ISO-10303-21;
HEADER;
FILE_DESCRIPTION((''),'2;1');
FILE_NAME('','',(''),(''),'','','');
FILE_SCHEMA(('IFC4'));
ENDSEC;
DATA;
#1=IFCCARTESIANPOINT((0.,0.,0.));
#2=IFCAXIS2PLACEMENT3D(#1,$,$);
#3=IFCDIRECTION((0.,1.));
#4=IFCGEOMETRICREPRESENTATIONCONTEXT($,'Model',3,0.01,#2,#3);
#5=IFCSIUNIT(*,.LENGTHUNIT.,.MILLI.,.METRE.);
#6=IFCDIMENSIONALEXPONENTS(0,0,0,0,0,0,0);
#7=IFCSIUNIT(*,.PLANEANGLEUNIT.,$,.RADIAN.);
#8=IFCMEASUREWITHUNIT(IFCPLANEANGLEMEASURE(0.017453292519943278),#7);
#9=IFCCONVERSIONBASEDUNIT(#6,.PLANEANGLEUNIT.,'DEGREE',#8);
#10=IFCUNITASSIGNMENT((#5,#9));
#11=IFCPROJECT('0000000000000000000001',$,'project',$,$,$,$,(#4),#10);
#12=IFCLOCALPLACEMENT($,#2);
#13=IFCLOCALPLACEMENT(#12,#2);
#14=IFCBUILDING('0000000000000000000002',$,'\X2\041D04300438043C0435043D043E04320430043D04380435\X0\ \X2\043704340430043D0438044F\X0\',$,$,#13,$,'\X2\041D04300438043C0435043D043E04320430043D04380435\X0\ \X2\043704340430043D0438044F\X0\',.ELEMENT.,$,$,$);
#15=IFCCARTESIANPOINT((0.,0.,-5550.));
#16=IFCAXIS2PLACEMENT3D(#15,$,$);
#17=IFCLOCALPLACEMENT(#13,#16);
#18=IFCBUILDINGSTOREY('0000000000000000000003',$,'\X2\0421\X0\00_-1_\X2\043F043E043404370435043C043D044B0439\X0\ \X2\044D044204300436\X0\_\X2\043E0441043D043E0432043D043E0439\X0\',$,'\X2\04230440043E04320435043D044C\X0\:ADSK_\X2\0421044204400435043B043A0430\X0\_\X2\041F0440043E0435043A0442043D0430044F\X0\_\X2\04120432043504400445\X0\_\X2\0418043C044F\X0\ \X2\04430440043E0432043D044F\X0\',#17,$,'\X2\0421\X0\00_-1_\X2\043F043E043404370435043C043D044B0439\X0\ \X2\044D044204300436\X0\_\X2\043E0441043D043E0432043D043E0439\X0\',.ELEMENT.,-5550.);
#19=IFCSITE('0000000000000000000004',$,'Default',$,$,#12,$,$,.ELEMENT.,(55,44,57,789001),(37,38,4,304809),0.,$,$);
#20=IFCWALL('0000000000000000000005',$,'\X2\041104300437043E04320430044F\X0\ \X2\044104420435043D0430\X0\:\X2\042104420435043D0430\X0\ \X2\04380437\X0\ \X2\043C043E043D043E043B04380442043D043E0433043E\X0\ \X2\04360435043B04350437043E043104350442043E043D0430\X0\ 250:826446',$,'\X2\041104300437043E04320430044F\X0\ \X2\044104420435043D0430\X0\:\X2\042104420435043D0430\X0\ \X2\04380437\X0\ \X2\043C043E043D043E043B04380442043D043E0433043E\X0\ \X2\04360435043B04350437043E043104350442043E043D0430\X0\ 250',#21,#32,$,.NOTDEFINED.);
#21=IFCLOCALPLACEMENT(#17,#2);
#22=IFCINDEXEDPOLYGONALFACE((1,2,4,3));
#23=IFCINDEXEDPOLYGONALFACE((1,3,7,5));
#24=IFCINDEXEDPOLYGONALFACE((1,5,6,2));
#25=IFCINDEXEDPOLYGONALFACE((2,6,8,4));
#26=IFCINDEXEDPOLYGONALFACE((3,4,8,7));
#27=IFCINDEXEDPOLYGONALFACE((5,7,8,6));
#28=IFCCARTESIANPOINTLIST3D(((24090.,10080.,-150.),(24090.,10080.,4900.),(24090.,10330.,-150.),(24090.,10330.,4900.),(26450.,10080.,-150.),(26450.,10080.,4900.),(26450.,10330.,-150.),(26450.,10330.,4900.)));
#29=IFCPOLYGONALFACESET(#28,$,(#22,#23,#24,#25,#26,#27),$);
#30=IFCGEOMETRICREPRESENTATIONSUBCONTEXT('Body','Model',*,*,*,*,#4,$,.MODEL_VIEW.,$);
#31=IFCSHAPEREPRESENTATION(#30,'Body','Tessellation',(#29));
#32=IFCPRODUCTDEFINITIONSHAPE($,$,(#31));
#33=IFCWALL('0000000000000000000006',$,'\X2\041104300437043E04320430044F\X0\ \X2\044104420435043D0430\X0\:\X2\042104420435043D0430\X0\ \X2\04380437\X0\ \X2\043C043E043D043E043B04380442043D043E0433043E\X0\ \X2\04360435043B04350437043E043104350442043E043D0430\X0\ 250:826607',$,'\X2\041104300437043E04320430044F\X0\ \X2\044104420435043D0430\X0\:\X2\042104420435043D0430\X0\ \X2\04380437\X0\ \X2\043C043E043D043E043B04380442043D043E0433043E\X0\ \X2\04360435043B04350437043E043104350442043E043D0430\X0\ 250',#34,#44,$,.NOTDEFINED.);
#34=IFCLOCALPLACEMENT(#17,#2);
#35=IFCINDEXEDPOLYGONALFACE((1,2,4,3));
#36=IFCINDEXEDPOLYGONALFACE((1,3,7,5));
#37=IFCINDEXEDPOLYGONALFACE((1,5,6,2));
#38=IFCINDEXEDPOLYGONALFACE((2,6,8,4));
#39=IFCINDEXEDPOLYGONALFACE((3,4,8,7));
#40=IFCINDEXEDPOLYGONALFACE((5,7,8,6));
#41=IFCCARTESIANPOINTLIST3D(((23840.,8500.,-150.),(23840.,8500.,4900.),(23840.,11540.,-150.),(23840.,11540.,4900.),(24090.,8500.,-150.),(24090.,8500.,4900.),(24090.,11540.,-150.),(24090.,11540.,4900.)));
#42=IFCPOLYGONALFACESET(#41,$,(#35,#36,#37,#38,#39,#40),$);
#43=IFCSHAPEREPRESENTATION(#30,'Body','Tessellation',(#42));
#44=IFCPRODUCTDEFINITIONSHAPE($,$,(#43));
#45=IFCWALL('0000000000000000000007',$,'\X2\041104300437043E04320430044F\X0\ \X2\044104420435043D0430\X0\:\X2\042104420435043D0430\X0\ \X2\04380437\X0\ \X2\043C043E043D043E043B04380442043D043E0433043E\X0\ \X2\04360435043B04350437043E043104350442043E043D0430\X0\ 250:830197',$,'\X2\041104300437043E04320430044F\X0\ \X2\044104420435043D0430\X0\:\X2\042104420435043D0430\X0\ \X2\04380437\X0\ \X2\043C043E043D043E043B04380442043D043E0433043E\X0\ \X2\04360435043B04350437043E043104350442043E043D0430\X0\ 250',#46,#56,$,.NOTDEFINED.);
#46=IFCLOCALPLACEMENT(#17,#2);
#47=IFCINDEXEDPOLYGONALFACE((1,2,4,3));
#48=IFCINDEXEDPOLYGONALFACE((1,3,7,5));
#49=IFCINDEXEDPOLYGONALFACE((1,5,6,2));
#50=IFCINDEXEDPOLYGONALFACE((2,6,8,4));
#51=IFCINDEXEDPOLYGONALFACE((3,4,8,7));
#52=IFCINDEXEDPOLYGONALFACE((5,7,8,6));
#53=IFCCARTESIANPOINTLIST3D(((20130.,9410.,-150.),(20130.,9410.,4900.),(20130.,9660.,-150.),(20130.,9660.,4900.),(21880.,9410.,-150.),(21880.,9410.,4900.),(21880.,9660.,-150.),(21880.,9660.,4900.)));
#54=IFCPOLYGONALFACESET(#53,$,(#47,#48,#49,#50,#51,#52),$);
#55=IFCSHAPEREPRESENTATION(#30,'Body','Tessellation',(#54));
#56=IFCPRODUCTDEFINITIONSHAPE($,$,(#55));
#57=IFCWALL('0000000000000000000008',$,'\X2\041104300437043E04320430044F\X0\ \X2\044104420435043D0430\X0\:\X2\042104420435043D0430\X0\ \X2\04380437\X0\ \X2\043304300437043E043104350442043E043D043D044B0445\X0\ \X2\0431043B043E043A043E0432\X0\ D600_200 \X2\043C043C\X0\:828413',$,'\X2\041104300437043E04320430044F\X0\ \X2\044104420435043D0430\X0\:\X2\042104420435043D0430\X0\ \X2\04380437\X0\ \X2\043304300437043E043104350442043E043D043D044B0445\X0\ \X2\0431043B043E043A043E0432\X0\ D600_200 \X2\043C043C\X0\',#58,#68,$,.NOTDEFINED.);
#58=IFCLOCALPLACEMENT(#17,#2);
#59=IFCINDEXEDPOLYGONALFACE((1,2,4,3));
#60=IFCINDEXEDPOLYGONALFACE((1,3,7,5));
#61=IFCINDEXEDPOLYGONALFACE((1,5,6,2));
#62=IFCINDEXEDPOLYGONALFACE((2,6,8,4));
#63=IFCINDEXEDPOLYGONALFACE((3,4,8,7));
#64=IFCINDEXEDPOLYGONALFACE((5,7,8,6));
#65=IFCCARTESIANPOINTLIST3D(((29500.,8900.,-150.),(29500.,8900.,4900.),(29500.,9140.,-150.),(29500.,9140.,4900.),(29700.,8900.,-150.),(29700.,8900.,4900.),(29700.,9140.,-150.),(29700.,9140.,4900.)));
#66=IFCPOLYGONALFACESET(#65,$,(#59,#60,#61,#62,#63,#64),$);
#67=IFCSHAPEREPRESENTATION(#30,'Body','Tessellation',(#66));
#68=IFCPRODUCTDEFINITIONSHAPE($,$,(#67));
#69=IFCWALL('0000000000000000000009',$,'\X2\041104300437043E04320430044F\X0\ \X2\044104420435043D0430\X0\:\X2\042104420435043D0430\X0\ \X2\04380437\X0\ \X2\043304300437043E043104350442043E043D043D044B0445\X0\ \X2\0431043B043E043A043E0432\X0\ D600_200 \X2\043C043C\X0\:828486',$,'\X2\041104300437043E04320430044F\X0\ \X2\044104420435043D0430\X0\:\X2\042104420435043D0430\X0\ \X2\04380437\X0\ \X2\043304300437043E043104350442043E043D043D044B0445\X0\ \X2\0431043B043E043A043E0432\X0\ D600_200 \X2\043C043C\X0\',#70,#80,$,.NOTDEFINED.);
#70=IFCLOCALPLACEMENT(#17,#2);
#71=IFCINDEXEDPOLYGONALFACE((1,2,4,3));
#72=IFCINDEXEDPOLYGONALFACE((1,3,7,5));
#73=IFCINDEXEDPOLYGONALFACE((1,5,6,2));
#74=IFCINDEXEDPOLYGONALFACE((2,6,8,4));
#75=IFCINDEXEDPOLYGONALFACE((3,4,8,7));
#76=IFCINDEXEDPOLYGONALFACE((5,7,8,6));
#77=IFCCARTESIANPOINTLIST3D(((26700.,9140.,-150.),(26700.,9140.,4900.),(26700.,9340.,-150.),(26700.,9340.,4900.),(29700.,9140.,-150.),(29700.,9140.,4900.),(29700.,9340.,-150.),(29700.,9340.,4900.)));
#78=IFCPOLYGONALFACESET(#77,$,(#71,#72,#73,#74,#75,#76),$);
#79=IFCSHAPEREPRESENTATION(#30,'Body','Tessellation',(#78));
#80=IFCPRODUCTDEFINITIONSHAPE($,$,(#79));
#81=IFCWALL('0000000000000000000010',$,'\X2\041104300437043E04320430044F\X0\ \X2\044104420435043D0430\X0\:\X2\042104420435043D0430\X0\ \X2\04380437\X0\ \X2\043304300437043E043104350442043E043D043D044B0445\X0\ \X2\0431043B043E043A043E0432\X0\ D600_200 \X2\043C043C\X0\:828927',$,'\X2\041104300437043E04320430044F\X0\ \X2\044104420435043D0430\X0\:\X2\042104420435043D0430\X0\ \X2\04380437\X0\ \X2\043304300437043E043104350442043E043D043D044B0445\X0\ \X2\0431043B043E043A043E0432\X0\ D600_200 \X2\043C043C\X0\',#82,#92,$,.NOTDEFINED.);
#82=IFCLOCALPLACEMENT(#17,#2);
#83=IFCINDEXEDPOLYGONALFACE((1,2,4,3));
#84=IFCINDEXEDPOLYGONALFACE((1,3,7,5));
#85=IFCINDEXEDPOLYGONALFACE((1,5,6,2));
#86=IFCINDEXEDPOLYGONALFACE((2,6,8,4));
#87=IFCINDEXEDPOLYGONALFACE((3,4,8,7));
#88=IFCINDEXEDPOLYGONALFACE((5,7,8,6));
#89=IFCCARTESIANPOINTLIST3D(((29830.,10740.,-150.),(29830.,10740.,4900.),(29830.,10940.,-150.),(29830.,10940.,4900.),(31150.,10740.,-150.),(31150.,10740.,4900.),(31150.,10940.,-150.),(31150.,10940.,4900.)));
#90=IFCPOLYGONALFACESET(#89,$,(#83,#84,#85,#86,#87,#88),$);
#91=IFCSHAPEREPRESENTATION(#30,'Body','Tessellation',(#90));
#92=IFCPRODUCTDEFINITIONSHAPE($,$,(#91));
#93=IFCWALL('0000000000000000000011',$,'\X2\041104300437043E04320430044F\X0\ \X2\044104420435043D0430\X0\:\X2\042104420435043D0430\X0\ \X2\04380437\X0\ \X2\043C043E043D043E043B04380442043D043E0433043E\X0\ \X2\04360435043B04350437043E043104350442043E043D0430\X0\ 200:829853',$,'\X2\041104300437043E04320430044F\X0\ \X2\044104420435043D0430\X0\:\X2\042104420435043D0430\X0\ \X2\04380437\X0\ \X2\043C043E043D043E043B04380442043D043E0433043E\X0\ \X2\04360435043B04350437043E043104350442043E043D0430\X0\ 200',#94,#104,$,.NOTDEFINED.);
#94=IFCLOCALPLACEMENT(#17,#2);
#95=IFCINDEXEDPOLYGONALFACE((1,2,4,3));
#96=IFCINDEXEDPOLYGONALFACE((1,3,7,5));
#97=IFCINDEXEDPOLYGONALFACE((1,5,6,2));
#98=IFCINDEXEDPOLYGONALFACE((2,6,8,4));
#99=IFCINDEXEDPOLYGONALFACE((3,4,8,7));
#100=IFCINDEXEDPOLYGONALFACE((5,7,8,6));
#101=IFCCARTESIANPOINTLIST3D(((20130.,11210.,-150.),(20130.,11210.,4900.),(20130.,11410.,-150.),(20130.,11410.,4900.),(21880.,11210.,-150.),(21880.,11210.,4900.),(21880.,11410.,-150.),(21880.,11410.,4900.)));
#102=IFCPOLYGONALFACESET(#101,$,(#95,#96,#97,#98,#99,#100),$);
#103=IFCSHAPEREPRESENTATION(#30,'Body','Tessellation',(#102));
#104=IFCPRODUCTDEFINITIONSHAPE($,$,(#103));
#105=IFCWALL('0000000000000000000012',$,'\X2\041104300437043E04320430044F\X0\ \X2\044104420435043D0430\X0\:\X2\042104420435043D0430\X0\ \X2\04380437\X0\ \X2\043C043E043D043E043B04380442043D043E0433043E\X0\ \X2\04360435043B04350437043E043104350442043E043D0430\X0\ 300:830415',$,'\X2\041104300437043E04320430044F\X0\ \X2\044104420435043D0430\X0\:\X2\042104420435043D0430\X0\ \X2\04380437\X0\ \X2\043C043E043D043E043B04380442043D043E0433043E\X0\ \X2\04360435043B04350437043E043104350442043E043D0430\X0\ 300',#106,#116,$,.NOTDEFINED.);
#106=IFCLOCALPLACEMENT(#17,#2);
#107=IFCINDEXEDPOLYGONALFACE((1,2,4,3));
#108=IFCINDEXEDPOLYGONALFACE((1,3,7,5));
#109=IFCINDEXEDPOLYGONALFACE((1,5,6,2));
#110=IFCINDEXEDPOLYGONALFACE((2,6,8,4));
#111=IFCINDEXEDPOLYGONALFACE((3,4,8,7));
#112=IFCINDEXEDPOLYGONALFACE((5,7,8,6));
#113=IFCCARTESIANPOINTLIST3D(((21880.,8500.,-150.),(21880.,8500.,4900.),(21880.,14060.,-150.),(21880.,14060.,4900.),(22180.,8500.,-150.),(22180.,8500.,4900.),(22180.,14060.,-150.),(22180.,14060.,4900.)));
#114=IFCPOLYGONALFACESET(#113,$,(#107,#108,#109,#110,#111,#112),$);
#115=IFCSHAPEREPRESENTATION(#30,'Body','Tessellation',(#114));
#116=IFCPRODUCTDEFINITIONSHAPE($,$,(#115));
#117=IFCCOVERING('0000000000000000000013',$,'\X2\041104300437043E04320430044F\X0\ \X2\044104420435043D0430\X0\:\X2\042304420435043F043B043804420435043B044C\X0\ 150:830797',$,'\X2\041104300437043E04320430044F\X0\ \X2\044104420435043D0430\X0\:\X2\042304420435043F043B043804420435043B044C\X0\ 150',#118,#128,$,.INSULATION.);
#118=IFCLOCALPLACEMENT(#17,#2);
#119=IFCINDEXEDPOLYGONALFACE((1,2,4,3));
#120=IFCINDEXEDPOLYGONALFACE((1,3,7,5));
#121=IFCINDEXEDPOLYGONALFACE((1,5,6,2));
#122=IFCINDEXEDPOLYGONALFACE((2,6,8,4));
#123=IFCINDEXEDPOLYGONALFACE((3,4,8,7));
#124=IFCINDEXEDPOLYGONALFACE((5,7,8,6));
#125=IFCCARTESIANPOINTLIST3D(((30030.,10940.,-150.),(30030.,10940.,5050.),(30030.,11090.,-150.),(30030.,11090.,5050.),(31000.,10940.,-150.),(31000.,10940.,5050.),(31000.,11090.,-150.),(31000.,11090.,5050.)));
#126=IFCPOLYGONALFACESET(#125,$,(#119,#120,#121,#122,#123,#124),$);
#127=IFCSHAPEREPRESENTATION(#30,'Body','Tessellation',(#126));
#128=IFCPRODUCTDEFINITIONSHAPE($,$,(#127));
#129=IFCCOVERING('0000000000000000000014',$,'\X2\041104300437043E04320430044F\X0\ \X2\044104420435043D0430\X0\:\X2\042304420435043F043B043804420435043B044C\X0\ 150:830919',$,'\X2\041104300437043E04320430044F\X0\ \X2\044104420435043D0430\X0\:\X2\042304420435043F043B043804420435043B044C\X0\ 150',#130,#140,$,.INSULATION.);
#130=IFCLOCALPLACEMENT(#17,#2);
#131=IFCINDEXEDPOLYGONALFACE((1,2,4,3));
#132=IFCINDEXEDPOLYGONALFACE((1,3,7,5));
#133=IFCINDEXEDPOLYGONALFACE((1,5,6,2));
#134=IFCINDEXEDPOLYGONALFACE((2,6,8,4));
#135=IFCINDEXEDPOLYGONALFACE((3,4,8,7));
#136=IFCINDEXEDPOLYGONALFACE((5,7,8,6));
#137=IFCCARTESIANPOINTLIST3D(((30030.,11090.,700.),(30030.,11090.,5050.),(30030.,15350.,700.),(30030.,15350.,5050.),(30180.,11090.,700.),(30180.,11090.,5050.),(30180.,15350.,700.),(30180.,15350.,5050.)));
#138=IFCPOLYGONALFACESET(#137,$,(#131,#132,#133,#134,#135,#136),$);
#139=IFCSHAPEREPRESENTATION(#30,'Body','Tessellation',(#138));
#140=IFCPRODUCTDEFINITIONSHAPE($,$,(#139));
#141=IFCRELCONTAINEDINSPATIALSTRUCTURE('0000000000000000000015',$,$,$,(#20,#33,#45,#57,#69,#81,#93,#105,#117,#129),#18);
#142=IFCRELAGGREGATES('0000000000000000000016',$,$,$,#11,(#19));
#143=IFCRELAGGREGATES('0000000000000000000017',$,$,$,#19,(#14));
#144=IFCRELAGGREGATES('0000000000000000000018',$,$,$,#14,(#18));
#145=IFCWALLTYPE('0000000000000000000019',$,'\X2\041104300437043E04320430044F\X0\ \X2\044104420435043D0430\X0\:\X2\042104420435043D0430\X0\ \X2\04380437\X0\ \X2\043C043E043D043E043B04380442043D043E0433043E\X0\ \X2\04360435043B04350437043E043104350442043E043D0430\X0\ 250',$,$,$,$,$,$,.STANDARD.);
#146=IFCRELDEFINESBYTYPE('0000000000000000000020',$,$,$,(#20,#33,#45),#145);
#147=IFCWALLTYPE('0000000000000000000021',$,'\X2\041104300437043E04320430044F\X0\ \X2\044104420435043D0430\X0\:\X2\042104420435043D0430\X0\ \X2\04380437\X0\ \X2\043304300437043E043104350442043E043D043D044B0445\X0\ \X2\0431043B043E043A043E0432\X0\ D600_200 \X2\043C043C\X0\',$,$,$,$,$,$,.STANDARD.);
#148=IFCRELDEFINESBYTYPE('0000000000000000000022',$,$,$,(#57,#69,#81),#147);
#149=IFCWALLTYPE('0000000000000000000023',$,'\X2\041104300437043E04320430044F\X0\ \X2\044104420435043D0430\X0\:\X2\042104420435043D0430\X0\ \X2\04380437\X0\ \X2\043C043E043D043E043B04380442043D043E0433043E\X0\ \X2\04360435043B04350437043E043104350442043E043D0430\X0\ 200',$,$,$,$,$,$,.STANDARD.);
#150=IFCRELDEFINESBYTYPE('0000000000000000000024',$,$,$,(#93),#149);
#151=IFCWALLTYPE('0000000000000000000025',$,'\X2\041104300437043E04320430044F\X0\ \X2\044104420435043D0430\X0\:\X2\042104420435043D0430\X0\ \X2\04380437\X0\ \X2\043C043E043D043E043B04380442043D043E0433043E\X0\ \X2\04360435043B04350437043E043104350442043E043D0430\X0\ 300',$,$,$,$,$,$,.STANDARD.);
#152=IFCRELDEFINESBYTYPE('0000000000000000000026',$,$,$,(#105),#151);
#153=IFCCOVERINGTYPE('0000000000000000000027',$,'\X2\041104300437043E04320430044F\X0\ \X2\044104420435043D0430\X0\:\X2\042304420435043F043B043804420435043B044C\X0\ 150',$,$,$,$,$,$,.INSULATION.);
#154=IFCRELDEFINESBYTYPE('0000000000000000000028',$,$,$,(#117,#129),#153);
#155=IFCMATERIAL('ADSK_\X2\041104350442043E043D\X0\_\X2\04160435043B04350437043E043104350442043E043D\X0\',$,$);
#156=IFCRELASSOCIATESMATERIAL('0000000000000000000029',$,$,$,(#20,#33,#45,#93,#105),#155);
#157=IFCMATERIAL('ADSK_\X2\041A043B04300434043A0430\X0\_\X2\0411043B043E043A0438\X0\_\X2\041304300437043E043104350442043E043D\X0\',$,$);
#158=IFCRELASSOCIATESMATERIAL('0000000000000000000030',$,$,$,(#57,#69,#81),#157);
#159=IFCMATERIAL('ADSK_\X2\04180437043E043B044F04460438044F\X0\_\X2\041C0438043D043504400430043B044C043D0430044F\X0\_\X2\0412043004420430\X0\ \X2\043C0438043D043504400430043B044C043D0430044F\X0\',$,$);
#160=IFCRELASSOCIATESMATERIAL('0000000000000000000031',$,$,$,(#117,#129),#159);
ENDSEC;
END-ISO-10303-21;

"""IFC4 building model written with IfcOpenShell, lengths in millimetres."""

from ifc_helpers import new_model, entity, si_unit, converted_unit, direction, frame, origin, place, context, subcontext, project, spatial, indexed_curve, outline, extrude, material, type_object, element, save


model = new_model("IFC4")

# Units and contexts
model_context = context("Model", 3, precision=0.01, world=origin(), true_north=direction((0.0, 1.0)))
body_context = subcontext(model_context, "Body", "Model", "MODEL_VIEW")
ifc_project = project(units=[si_unit("LENGTHUNIT", "METRE", prefix="MILLI"), converted_unit("PLANEANGLEUNIT", "DEGREE", entity("IfcPlaneAngleMeasure", 0.017453292519943278), si_unit("PLANEANGLEUNIT", "RADIAN"), dimensions=[0, 0, 0, 0, 0, 0, 0])], contexts=[model_context])

# Site, building, storey
site_placement = place(None, origin())
site = spatial("IfcSite", under=ifc_project, at=site_placement, Name="Default", CompositionType="ELEMENT", RefLatitude=(55, 44, 57, 789001), RefLongitude=(37, 38, 4, 304809), RefElevation=0.0)
building_placement = place(site_placement, origin())
building = spatial("IfcBuilding", under=site, at=building_placement, Name="Наименование здания", LongName="Наименование здания", CompositionType="ELEMENT")
storey_placement = place(building_placement, frame((0.0, 0.0, -5550.0)))
storey = spatial("IfcBuildingStorey", under=building, at=storey_placement, Name="С00_-1_подземный этаж_основной", ObjectType="Уровень:ADSK_Стрелка_Проектная_Вверх_Имя уровня", LongName="С00_-1_подземный этаж_основной", CompositionType="ELEMENT", Elevation=-5550.0)

# Shared definitions
ifc_material_1 = material(Name="ADSK_Бетон_Железобетон")

# Walls
wall_type_1 = type_object("IfcWallType", Name="Базовая стена:Стена из монолитного железобетона 250", PredefinedType="STANDARD")
wall_1_placement = place(storey_placement, frame((26450.0, 10205.0, -150.0), z_axis=(0.0, 0.0, 1.0), x_axis=(-1.0, 0.0, 0.0)))
element("IfcWall", 1, at=wall_1_placement, inside=storey, type_object=wall_type_1, material=ifc_material_1, Name="Базовая стена:Стена из монолитного железобетона 250:826446", ObjectType="Базовая стена:Стена из монолитного железобетона 250", PredefinedType="NOTDEFINED", context=body_context, shape_type="SweptSolid", body=[
    extrude(outline(indexed_curve([(2360.0, 125.0), (0.0, 125.0), (0.0, -125.0), (2360.0, -125.0), (2360.0, 125.0)], self_intersect=False)), origin(), (0.0, 0.0, 1.0), 5050.0),
])
wall_2_placement = place(storey_placement, frame((23965.0, 8500.0, -150.0), z_axis=(0.0, 0.0, 1.0), x_axis=(0.0, 1.0, 0.0)))
element("IfcWall", 2, at=wall_2_placement, inside=storey, type_object=wall_type_1, material=ifc_material_1, Name="Базовая стена:Стена из монолитного железобетона 250:826607", ObjectType="Базовая стена:Стена из монолитного железобетона 250", PredefinedType="NOTDEFINED", context=body_context, shape_type="SweptSolid", body=[
    extrude(outline(indexed_curve([(3040.0, 125.0), (0.0, 125.0), (0.0, -125.0), (3040.0, -125.0), (3040.0, 125.0)], self_intersect=False)), origin(), (0.0, 0.0, 1.0), 5050.0),
])
wall_3_placement = place(storey_placement, frame((20130.0, 9535.0, -150.0)))
element("IfcWall", 3, at=wall_3_placement, inside=storey, type_object=wall_type_1, material=ifc_material_1, Name="Базовая стена:Стена из монолитного железобетона 250:830197", ObjectType="Базовая стена:Стена из монолитного железобетона 250", PredefinedType="NOTDEFINED", context=body_context, shape_type="SweptSolid", body=[
    extrude(outline(indexed_curve([(1750.0, 125.0), (0.0, 125.0), (0.0, -125.0), (1750.0, -125.0), (1750.0, 125.0)], self_intersect=False)), origin(), (0.0, 0.0, 1.0), 5050.0),
])
ifc_material_2 = material(Name="ADSK_Кладка_Блоки_Газобетон")
wall_type_2 = type_object("IfcWallType", Name="Базовая стена:Стена из газобетонных блоков D600_200 мм", PredefinedType="STANDARD")
wall_4_placement = place(storey_placement, frame((29600.0, 8900.0, -150.0), z_axis=(0.0, 0.0, 1.0), x_axis=(0.0, 1.0, 0.0)))
element("IfcWall", 4, at=wall_4_placement, inside=storey, type_object=wall_type_2, material=ifc_material_2, Name="Базовая стена:Стена из газобетонных блоков D600_200 мм:828413", ObjectType="Базовая стена:Стена из газобетонных блоков D600_200 мм", PredefinedType="NOTDEFINED", context=body_context, shape_type="SweptSolid", body=[
    extrude(outline(indexed_curve([(240.0, 100.0), (0.0, 100.0), (0.0, -100.0), (240.0, -100.0), (240.0, 100.0)], self_intersect=False)), origin(), (0.0, 0.0, 1.0), 5050.0),
])
wall_5_placement = place(storey_placement, frame((29700.0, 9240.0, -150.0), z_axis=(0.0, 0.0, 1.0), x_axis=(-1.0, 0.0, 0.0)))
element("IfcWall", 5, at=wall_5_placement, inside=storey, type_object=wall_type_2, material=ifc_material_2, Name="Базовая стена:Стена из газобетонных блоков D600_200 мм:828486", ObjectType="Базовая стена:Стена из газобетонных блоков D600_200 мм", PredefinedType="NOTDEFINED", context=body_context, shape_type="SweptSolid", body=[
    extrude(outline(indexed_curve([(3000.0, 100.0), (0.0, 100.0), (0.0, -100.0), (3000.0, -100.0), (3000.0, 100.0)], self_intersect=False)), origin(), (0.0, 0.0, 1.0), 5050.0),
])
wall_6_placement = place(storey_placement, frame((29830.0, 10840.0, -150.0)))
element("IfcWall", 6, at=wall_6_placement, inside=storey, type_object=wall_type_2, material=ifc_material_2, Name="Базовая стена:Стена из газобетонных блоков D600_200 мм:828927", ObjectType="Базовая стена:Стена из газобетонных блоков D600_200 мм", PredefinedType="NOTDEFINED", context=body_context, shape_type="SweptSolid", body=[
    extrude(outline(indexed_curve([(1320.0, 100.0), (0.0, 100.0), (0.0, -100.0), (1320.0, -100.0), (1320.0, 100.0)], self_intersect=False)), origin(), (0.0, 0.0, 1.0), 5050.0),
])
wall_type_3 = type_object("IfcWallType", Name="Базовая стена:Стена из монолитного железобетона 200", PredefinedType="STANDARD")
wall_7_placement = place(storey_placement, frame((20130.0, 11310.0, -150.0)))
element("IfcWall", 7, at=wall_7_placement, inside=storey, type_object=wall_type_3, material=ifc_material_1, Name="Базовая стена:Стена из монолитного железобетона 200:829853", ObjectType="Базовая стена:Стена из монолитного железобетона 200", PredefinedType="NOTDEFINED", context=body_context, shape_type="SweptSolid", body=[
    extrude(outline(indexed_curve([(1750.0, 100.0), (0.0, 100.0), (0.0, -100.0), (1750.0, -100.0), (1750.0, 100.0)], self_intersect=False)), origin(), (0.0, 0.0, 1.0), 5050.0),
])
wall_type_4 = type_object("IfcWallType", Name="Базовая стена:Стена из монолитного железобетона 300", PredefinedType="STANDARD")
wall_8_placement = place(storey_placement, frame((22030.0, 8500.0, -150.0), z_axis=(0.0, 0.0, 1.0), x_axis=(0.0, 1.0, 0.0)))
element("IfcWall", 8, at=wall_8_placement, inside=storey, type_object=wall_type_4, material=ifc_material_1, Name="Базовая стена:Стена из монолитного железобетона 300:830415", ObjectType="Базовая стена:Стена из монолитного железобетона 300", PredefinedType="NOTDEFINED", context=body_context, shape_type="SweptSolid", body=[
    extrude(outline(indexed_curve([(5560.0, 150.0), (0.0, 150.0), (0.0, -150.0), (5560.0, -150.0), (5560.0, 150.0)], self_intersect=False)), origin(), (0.0, 0.0, 1.0), 5050.0),
])

# Coverings
ifc_material_3 = material(Name="ADSK_Изоляция_Минеральная_Вата минеральная")
covering_type = type_object("IfcCoveringType", Name="Базовая стена:Утеплитель 150", PredefinedType="INSULATION")
covering_1_placement = place(storey_placement, frame((31000.0, 11015.0, -150.0), z_axis=(0.0, 0.0, 1.0), x_axis=(-1.0, 0.0, 0.0)))
element("IfcCovering", 9, at=covering_1_placement, inside=storey, type_object=covering_type, material=ifc_material_3, Name="Базовая стена:Утеплитель 150:830797", ObjectType="Базовая стена:Утеплитель 150", PredefinedType="INSULATION", context=body_context, shape_type="SweptSolid", body=[
    extrude(outline(indexed_curve([(970.0, 75.0), (0.0, 75.0), (0.0, -75.0), (970.0, -75.0), (970.0, 75.0)], self_intersect=False)), origin(), (0.0, 0.0, 1.0), 5200.0),
])
covering_2_placement = place(storey_placement, frame((30105.0, 11090.0, 700.0), z_axis=(0.0, 0.0, 1.0), x_axis=(0.0, 1.0, 0.0)))
element("IfcCovering", 10, at=covering_2_placement, inside=storey, type_object=covering_type, material=ifc_material_3, Name="Базовая стена:Утеплитель 150:830919", ObjectType="Базовая стена:Утеплитель 150", PredefinedType="INSULATION", context=body_context, shape_type="SweptSolid", body=[
    extrude(outline(indexed_curve([(4260.0, 75.0), (0.0, 75.0), (0.0, -75.0), (4260.0, -75.0), (4260.0, 75.0)], self_intersect=False)), origin(), (0.0, 0.0, 1.0), 4350.0),
])

save(model, "model.ifc")
